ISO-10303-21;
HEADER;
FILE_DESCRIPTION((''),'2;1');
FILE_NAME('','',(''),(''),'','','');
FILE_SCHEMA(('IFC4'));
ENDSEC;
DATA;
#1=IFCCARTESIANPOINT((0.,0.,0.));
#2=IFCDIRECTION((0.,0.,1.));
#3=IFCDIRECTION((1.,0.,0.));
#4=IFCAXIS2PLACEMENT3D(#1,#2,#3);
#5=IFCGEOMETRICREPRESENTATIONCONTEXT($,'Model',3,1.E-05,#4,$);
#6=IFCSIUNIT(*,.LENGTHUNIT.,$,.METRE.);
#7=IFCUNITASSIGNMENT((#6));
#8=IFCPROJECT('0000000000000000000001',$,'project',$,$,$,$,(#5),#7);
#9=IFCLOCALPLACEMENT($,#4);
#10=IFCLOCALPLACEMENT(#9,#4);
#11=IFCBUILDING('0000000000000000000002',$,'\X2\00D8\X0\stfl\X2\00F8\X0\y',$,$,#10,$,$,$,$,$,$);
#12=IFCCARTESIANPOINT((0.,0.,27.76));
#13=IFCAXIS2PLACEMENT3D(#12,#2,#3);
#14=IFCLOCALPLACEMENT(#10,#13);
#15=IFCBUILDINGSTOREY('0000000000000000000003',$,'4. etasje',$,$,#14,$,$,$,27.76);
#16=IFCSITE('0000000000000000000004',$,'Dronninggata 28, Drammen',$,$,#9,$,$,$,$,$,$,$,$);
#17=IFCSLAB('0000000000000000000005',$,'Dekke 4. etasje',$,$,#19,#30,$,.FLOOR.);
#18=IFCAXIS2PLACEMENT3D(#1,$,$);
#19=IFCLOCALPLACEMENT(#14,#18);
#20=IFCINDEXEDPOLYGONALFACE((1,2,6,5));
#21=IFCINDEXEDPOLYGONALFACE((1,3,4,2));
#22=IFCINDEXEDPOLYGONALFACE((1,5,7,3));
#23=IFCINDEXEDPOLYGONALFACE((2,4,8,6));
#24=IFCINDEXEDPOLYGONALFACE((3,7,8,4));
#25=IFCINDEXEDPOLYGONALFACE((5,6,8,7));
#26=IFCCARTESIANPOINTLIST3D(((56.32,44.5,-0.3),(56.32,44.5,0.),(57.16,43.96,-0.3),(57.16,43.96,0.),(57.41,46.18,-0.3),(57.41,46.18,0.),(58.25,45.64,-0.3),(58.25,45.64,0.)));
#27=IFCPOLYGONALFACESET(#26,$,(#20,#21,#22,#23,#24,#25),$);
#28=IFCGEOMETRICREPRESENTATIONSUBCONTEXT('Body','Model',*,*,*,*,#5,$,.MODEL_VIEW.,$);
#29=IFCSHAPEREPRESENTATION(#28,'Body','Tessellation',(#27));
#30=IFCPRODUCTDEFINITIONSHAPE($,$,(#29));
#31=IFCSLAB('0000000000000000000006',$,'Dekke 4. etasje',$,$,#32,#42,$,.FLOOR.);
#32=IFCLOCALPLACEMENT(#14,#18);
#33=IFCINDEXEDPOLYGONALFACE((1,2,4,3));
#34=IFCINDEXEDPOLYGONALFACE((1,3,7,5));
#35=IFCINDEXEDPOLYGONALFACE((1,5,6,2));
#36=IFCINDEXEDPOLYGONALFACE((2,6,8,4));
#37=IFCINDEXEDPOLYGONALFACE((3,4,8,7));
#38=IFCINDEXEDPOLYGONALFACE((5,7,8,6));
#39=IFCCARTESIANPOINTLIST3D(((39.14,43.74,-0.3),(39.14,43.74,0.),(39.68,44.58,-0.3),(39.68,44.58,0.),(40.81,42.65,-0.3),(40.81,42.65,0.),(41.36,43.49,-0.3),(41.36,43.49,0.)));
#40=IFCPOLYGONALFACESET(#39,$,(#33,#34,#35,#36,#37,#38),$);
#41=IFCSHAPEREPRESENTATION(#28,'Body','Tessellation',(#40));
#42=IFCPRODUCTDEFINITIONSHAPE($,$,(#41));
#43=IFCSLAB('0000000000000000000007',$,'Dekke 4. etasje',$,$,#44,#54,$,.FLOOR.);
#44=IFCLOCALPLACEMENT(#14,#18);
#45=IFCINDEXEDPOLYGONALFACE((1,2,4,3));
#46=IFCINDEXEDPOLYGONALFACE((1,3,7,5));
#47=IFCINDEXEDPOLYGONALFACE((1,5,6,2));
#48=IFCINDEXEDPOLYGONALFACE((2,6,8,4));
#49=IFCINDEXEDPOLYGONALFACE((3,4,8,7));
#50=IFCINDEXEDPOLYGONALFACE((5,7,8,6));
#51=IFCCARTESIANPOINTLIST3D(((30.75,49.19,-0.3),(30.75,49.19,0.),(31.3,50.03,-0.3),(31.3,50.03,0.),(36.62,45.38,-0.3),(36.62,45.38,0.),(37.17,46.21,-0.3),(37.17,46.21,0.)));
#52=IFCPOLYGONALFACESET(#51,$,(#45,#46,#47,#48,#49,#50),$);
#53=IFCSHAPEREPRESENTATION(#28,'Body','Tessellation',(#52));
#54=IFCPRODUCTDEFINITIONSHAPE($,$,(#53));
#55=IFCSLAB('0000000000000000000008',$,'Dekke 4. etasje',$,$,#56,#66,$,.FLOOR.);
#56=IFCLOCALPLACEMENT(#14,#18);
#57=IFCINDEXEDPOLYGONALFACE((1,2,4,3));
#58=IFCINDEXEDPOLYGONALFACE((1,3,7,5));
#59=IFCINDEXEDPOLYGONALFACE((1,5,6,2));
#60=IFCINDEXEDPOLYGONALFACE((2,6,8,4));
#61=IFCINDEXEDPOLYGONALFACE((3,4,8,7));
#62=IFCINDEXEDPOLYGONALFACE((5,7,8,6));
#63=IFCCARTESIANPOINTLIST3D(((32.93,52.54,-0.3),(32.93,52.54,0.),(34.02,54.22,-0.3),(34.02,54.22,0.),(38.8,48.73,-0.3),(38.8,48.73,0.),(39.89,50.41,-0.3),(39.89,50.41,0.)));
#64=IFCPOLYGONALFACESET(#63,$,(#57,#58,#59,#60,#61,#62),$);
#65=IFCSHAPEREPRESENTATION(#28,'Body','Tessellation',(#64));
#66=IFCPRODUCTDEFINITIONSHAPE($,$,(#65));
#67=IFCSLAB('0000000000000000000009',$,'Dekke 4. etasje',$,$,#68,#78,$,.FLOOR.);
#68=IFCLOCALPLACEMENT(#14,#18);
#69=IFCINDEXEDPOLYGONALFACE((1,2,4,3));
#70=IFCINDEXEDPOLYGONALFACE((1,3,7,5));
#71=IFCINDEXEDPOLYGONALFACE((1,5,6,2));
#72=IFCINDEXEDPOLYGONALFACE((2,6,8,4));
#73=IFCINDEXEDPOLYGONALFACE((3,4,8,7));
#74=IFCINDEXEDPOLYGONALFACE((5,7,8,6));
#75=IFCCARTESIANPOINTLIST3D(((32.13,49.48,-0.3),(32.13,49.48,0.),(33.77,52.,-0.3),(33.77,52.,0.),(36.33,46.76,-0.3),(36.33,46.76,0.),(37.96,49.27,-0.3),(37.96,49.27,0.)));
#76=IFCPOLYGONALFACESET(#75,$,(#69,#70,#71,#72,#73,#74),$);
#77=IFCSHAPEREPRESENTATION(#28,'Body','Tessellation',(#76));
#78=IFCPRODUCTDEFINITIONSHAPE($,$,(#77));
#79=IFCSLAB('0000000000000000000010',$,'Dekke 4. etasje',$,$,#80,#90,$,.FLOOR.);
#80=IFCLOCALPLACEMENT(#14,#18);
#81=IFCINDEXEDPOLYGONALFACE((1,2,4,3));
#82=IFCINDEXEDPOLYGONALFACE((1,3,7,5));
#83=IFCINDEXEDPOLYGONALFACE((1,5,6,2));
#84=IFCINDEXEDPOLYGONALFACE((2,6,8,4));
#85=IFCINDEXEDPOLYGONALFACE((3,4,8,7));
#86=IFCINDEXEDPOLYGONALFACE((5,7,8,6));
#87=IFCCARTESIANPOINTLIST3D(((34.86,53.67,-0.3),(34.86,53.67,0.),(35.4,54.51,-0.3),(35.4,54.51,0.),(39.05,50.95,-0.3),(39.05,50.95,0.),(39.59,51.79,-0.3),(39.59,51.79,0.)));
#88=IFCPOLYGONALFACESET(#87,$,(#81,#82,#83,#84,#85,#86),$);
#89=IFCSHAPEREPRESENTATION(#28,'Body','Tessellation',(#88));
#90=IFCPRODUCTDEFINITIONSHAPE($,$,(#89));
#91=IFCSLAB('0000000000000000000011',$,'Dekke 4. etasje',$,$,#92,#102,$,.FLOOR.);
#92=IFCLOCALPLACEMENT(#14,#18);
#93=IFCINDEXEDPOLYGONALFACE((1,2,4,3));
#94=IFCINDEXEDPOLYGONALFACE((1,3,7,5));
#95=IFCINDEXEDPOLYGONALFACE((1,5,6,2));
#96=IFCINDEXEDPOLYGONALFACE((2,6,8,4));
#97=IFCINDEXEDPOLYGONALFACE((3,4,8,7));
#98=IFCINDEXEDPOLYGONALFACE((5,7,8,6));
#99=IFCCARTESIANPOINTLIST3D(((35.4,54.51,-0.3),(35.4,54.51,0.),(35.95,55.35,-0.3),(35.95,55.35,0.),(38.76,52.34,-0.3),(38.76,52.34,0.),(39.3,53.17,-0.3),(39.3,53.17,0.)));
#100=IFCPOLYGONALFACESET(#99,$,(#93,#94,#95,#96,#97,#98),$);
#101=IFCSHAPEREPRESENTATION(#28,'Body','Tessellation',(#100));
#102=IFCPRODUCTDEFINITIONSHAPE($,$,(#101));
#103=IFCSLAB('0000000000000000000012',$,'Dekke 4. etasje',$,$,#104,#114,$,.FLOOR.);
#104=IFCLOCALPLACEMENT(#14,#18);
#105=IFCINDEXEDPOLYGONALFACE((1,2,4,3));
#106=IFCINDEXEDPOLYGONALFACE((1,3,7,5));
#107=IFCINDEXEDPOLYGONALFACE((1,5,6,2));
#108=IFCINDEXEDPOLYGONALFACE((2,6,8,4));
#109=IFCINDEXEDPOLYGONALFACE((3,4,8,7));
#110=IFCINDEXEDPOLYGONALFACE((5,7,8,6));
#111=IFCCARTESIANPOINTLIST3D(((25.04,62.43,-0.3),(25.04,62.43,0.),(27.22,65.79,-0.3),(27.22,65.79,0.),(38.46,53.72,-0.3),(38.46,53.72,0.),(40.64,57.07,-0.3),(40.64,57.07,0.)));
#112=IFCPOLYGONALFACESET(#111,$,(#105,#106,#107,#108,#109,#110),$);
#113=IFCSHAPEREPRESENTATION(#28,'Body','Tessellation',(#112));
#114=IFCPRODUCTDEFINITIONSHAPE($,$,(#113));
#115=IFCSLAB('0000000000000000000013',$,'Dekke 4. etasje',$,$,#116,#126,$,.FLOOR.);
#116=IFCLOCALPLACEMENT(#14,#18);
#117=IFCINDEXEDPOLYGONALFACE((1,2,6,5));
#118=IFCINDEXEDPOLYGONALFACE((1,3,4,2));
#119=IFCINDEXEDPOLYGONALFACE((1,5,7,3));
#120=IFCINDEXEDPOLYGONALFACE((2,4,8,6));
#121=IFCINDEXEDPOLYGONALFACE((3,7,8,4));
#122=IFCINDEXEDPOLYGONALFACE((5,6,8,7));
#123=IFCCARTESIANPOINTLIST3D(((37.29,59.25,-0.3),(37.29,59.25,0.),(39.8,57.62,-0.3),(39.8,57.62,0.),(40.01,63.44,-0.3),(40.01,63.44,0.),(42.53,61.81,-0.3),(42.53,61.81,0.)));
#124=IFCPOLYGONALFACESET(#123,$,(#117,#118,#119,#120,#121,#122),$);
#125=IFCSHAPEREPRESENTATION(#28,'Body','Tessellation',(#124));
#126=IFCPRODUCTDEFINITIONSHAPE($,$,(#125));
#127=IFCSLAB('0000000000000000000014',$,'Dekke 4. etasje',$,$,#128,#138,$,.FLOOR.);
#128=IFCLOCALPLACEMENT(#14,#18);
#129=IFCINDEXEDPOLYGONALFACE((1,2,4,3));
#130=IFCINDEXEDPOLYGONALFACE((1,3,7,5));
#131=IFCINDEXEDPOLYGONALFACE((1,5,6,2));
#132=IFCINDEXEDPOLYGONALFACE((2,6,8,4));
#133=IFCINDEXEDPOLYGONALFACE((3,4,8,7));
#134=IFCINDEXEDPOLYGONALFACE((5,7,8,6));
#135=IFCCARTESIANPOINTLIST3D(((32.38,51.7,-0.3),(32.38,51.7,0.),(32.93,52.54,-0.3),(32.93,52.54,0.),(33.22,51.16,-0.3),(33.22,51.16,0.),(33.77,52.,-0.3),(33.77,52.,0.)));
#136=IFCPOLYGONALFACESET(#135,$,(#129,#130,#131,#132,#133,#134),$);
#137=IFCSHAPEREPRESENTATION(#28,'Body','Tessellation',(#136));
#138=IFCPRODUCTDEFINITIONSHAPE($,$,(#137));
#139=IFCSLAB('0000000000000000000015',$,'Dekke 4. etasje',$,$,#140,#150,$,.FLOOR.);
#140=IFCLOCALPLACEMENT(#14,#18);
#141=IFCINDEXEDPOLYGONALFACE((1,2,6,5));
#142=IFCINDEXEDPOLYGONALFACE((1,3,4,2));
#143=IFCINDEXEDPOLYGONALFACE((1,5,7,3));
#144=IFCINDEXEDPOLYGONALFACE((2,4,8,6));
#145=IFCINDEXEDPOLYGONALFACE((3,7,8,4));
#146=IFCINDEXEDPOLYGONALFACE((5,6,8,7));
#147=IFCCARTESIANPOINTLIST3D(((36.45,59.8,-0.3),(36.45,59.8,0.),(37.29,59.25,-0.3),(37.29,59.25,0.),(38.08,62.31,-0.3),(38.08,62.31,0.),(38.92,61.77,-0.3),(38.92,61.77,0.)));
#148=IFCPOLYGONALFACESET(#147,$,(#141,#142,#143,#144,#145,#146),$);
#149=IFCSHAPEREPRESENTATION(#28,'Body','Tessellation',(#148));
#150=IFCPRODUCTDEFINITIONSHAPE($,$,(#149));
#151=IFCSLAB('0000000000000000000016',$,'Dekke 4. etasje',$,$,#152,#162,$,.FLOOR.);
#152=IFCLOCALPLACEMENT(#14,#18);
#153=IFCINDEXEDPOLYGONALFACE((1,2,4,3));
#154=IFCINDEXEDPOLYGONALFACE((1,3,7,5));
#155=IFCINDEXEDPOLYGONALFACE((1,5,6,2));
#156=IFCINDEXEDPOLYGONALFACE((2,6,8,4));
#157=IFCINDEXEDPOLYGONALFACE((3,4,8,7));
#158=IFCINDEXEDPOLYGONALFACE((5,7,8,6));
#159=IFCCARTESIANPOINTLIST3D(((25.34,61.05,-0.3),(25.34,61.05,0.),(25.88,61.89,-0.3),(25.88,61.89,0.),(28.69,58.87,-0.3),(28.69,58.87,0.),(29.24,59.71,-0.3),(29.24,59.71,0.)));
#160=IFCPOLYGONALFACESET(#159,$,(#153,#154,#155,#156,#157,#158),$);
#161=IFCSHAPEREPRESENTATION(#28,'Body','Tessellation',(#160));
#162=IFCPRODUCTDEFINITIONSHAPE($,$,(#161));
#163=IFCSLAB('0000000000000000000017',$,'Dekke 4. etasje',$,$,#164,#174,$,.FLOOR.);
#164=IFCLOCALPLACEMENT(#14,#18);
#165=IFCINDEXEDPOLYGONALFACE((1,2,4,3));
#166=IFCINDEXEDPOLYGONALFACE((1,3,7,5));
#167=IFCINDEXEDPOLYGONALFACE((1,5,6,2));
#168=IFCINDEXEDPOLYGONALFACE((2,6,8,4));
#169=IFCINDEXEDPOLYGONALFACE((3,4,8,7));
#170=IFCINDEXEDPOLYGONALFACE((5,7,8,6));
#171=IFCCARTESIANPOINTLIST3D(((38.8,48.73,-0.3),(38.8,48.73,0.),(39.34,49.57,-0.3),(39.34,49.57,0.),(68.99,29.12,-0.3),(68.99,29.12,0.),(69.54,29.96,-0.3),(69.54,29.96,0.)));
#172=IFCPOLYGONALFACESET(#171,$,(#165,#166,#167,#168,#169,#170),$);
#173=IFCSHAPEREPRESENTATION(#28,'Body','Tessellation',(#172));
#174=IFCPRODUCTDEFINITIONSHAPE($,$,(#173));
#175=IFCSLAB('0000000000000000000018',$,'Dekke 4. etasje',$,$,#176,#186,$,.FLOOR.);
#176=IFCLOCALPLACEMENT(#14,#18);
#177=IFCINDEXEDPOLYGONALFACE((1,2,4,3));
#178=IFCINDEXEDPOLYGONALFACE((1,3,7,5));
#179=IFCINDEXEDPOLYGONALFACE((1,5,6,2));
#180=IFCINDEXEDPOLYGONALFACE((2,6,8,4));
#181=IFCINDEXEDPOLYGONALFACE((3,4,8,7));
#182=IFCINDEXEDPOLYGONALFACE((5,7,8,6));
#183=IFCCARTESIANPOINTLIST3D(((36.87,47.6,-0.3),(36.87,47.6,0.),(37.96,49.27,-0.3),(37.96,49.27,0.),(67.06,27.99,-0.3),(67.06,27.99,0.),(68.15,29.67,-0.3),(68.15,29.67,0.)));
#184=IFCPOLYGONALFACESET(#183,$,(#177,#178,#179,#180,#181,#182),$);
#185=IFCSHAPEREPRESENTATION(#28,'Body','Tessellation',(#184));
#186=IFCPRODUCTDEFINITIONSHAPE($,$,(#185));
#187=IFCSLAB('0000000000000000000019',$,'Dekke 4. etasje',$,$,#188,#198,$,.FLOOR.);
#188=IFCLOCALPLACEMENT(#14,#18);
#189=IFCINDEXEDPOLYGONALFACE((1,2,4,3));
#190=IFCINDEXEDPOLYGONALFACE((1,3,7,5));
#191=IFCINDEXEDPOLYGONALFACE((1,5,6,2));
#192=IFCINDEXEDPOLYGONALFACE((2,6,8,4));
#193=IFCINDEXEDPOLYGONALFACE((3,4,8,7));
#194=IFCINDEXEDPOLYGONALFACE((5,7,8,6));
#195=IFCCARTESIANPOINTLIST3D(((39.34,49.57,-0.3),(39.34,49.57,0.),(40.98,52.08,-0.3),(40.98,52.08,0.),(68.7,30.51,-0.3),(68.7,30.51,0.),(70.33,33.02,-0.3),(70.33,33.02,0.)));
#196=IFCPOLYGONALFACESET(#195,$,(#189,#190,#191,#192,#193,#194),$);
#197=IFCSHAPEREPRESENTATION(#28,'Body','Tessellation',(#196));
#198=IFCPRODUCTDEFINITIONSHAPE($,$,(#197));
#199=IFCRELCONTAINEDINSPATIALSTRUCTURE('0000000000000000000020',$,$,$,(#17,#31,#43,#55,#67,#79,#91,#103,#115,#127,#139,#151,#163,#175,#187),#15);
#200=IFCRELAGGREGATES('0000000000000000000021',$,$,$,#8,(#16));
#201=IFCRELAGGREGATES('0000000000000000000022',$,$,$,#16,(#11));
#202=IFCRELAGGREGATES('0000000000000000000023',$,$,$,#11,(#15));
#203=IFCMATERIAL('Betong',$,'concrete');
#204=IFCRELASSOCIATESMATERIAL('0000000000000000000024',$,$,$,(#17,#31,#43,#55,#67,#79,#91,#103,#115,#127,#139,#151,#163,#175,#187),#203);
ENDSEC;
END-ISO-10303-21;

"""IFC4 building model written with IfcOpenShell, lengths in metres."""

from ifc_helpers import new_model, si_unit, frame, origin_with_axes, place, context, subcontext, project, spatial, polyline, outline, extrude, material, element, save


model = new_model("IFC4")

# Units and contexts
model_context = context("Model", 3, precision=1e-05, world=origin_with_axes())
body_context = subcontext(model_context, "Body", "Model", "MODEL_VIEW")
ifc_project = project(units=[si_unit("LENGTHUNIT", "METRE")], contexts=[model_context])

# Site, building, storey
site_placement = place(None, origin_with_axes())
site = spatial("IfcSite", under=ifc_project, at=site_placement, Name="Dronninggata 28, Drammen")
building_placement = place(site_placement, origin_with_axes())
building = spatial("IfcBuilding", under=site, at=building_placement, Name="Østfløy")
storey_placement = place(building_placement, frame((0.0, 0.0, 27.76), z_axis=(0.0, 0.0, 1.0), x_axis=(1.0, 0.0, 0.0)))
storey = spatial("IfcBuildingStorey", under=building, at=storey_placement, Name="4. etasje", Elevation=27.76)

# Slabs
ifc_material = material(Name="Betong", Category="concrete")
slab_1_placement = place(storey_placement, frame((0.0, 0.0, -27.76), z_axis=(0.0, 0.0, 1.0), x_axis=(1.0, 0.0, 0.0)))
element("IfcSlab", 1, at=slab_1_placement, inside=storey, material=ifc_material, Name="Dekke 4. etasje", PredefinedType="FLOOR", context=body_context, shape_type="SweptSolid", body=[
    extrude(outline(polyline([(57.16, 43.96), (58.25, 45.64), (57.41, 46.18), (56.32, 44.5), (57.16, 43.96)])), frame((0.0, 0.0, 27.46)), (0.0, 0.0, 1.0), 0.3),
])
slab_2_placement = place(storey_placement, frame((0.0, 0.0, -27.76), z_axis=(0.0, 0.0, 1.0), x_axis=(1.0, 0.0, 0.0)))
element("IfcSlab", 2, at=slab_2_placement, inside=storey, material=ifc_material, Name="Dekke 4. etasje", PredefinedType="FLOOR", context=body_context, shape_type="SweptSolid", body=[
    extrude(outline(polyline([(40.81, 42.65), (41.36, 43.49), (39.68, 44.58), (39.14, 43.74), (40.81, 42.65)])), frame((0.0, 0.0, 27.46)), (0.0, 0.0, 1.0), 0.3),
])
slab_3_placement = place(storey_placement, frame((0.0, 0.0, -27.76), z_axis=(0.0, 0.0, 1.0), x_axis=(1.0, 0.0, 0.0)))
element("IfcSlab", 3, at=slab_3_placement, inside=storey, material=ifc_material, Name="Dekke 4. etasje", PredefinedType="FLOOR", context=body_context, shape_type="SweptSolid", body=[
    extrude(outline(polyline([(36.62, 45.38), (37.17, 46.21), (31.3, 50.03), (30.75, 49.19), (36.62, 45.38)])), frame((0.0, 0.0, 27.46)), (0.0, 0.0, 1.0), 0.3),
])
slab_4_placement = place(storey_placement, frame((0.0, 0.0, -27.76), z_axis=(0.0, 0.0, 1.0), x_axis=(1.0, 0.0, 0.0)))
element("IfcSlab", 4, at=slab_4_placement, inside=storey, material=ifc_material, Name="Dekke 4. etasje", PredefinedType="FLOOR", context=body_context, shape_type="SweptSolid", body=[
    extrude(outline(polyline([(38.8, 48.73), (39.89, 50.41), (34.02, 54.22), (32.93, 52.54), (38.8, 48.73)])), frame((0.0, 0.0, 27.46)), (0.0, 0.0, 1.0), 0.3),
])
slab_5_placement = place(storey_placement, frame((0.0, 0.0, -27.76), z_axis=(0.0, 0.0, 1.0), x_axis=(1.0, 0.0, 0.0)))
element("IfcSlab", 5, at=slab_5_placement, inside=storey, material=ifc_material, Name="Dekke 4. etasje", PredefinedType="FLOOR", context=body_context, shape_type="SweptSolid", body=[
    extrude(outline(polyline([(36.33, 46.76), (37.96, 49.27), (33.77, 52.0), (32.13, 49.48), (36.33, 46.76)])), frame((0.0, 0.0, 27.46)), (0.0, 0.0, 1.0), 0.3),
])
slab_6_placement = place(storey_placement, frame((0.0, 0.0, -27.76), z_axis=(0.0, 0.0, 1.0), x_axis=(1.0, 0.0, 0.0)))
element("IfcSlab", 6, at=slab_6_placement, inside=storey, material=ifc_material, Name="Dekke 4. etasje", PredefinedType="FLOOR", context=body_context, shape_type="SweptSolid", body=[
    extrude(outline(polyline([(39.05, 50.95), (39.59, 51.79), (35.4, 54.51), (34.86, 53.67), (39.05, 50.95)])), frame((0.0, 0.0, 27.46)), (0.0, 0.0, 1.0), 0.3),
])
slab_7_placement = place(storey_placement, frame((0.0, 0.0, -27.76), z_axis=(0.0, 0.0, 1.0), x_axis=(1.0, 0.0, 0.0)))
element("IfcSlab", 7, at=slab_7_placement, inside=storey, material=ifc_material, Name="Dekke 4. etasje", PredefinedType="FLOOR", context=body_context, shape_type="SweptSolid", body=[
    extrude(outline(polyline([(38.76, 52.34), (39.3, 53.17), (35.95, 55.35), (35.4, 54.51), (38.76, 52.34)])), frame((0.0, 0.0, 27.46)), (0.0, 0.0, 1.0), 0.3),
])
slab_8_placement = place(storey_placement, frame((0.0, 0.0, -27.76), z_axis=(0.0, 0.0, 1.0), x_axis=(1.0, 0.0, 0.0)))
element("IfcSlab", 8, at=slab_8_placement, inside=storey, material=ifc_material, Name="Dekke 4. etasje", PredefinedType="FLOOR", context=body_context, shape_type="SweptSolid", body=[
    extrude(outline(polyline([(38.46, 53.72), (40.64, 57.07), (27.22, 65.79), (25.04, 62.43), (38.46, 53.72)])), frame((0.0, 0.0, 27.46)), (0.0, 0.0, 1.0), 0.3),
])
slab_9_placement = place(storey_placement, frame((0.0, 0.0, -27.76), z_axis=(0.0, 0.0, 1.0), x_axis=(1.0, 0.0, 0.0)))
element("IfcSlab", 9, at=slab_9_placement, inside=storey, material=ifc_material, Name="Dekke 4. etasje", PredefinedType="FLOOR", context=body_context, shape_type="SweptSolid", body=[
    extrude(outline(polyline([(39.8, 57.62), (42.53, 61.81), (40.01, 63.44), (37.29, 59.25), (39.8, 57.62)])), frame((0.0, 0.0, 27.46)), (0.0, 0.0, 1.0), 0.3),
])
slab_10_placement = place(storey_placement, frame((0.0, 0.0, -27.76), z_axis=(0.0, 0.0, 1.0), x_axis=(1.0, 0.0, 0.0)))
element("IfcSlab", 10, at=slab_10_placement, inside=storey, material=ifc_material, Name="Dekke 4. etasje", PredefinedType="FLOOR", context=body_context, shape_type="SweptSolid", body=[
    extrude(outline(polyline([(33.22, 51.16), (33.77, 52.0), (32.93, 52.54), (32.38, 51.7), (33.22, 51.16)])), frame((0.0, 0.0, 27.46)), (0.0, 0.0, 1.0), 0.3),
])
slab_11_placement = place(storey_placement, frame((0.0, 0.0, -27.76), z_axis=(0.0, 0.0, 1.0), x_axis=(1.0, 0.0, 0.0)))
element("IfcSlab", 11, at=slab_11_placement, inside=storey, material=ifc_material, Name="Dekke 4. etasje", PredefinedType="FLOOR", context=body_context, shape_type="SweptSolid", body=[
    extrude(outline(polyline([(37.29, 59.25), (38.92, 61.77), (38.08, 62.31), (36.45, 59.8), (37.29, 59.25)])), frame((0.0, 0.0, 27.46)), (0.0, 0.0, 1.0), 0.3),
])
slab_12_placement = place(storey_placement, frame((0.0, 0.0, -27.76), z_axis=(0.0, 0.0, 1.0), x_axis=(1.0, 0.0, 0.0)))
element("IfcSlab", 12, at=slab_12_placement, inside=storey, material=ifc_material, Name="Dekke 4. etasje", PredefinedType="FLOOR", context=body_context, shape_type="SweptSolid", body=[
    extrude(outline(polyline([(28.69, 58.87), (29.24, 59.71), (25.88, 61.89), (25.34, 61.05), (28.69, 58.87)])), frame((0.0, 0.0, 27.46)), (0.0, 0.0, 1.0), 0.3),
])
slab_13_placement = place(storey_placement, frame((0.0, 0.0, -27.76), z_axis=(0.0, 0.0, 1.0), x_axis=(1.0, 0.0, 0.0)))
element("IfcSlab", 13, at=slab_13_placement, inside=storey, material=ifc_material, Name="Dekke 4. etasje", PredefinedType="FLOOR", context=body_context, shape_type="SweptSolid", body=[
    extrude(outline(polyline([(68.99, 29.12), (69.54, 29.96), (39.34, 49.57), (38.8, 48.73), (68.99, 29.12)])), frame((0.0, 0.0, 27.46)), (0.0, 0.0, 1.0), 0.3),
])
slab_14_placement = place(storey_placement, frame((0.0, 0.0, -27.76), z_axis=(0.0, 0.0, 1.0), x_axis=(1.0, 0.0, 0.0)))
element("IfcSlab", 14, at=slab_14_placement, inside=storey, material=ifc_material, Name="Dekke 4. etasje", PredefinedType="FLOOR", context=body_context, shape_type="SweptSolid", body=[
    extrude(outline(polyline([(67.06, 27.99), (68.15, 29.67), (37.96, 49.27), (36.87, 47.6), (67.06, 27.99)])), frame((0.0, 0.0, 27.46)), (0.0, 0.0, 1.0), 0.3),
])
slab_15_placement = place(storey_placement, frame((0.0, 0.0, -27.76), z_axis=(0.0, 0.0, 1.0), x_axis=(1.0, 0.0, 0.0)))
element("IfcSlab", 15, at=slab_15_placement, inside=storey, material=ifc_material, Name="Dekke 4. etasje", PredefinedType="FLOOR", context=body_context, shape_type="SweptSolid", body=[
    extrude(outline(polyline([(68.7, 30.51), (70.33, 33.02), (40.98, 52.08), (39.34, 49.57), (68.7, 30.51)])), frame((0.0, 0.0, 27.46)), (0.0, 0.0, 1.0), 0.3),
])

save(model, "model.ifc")
